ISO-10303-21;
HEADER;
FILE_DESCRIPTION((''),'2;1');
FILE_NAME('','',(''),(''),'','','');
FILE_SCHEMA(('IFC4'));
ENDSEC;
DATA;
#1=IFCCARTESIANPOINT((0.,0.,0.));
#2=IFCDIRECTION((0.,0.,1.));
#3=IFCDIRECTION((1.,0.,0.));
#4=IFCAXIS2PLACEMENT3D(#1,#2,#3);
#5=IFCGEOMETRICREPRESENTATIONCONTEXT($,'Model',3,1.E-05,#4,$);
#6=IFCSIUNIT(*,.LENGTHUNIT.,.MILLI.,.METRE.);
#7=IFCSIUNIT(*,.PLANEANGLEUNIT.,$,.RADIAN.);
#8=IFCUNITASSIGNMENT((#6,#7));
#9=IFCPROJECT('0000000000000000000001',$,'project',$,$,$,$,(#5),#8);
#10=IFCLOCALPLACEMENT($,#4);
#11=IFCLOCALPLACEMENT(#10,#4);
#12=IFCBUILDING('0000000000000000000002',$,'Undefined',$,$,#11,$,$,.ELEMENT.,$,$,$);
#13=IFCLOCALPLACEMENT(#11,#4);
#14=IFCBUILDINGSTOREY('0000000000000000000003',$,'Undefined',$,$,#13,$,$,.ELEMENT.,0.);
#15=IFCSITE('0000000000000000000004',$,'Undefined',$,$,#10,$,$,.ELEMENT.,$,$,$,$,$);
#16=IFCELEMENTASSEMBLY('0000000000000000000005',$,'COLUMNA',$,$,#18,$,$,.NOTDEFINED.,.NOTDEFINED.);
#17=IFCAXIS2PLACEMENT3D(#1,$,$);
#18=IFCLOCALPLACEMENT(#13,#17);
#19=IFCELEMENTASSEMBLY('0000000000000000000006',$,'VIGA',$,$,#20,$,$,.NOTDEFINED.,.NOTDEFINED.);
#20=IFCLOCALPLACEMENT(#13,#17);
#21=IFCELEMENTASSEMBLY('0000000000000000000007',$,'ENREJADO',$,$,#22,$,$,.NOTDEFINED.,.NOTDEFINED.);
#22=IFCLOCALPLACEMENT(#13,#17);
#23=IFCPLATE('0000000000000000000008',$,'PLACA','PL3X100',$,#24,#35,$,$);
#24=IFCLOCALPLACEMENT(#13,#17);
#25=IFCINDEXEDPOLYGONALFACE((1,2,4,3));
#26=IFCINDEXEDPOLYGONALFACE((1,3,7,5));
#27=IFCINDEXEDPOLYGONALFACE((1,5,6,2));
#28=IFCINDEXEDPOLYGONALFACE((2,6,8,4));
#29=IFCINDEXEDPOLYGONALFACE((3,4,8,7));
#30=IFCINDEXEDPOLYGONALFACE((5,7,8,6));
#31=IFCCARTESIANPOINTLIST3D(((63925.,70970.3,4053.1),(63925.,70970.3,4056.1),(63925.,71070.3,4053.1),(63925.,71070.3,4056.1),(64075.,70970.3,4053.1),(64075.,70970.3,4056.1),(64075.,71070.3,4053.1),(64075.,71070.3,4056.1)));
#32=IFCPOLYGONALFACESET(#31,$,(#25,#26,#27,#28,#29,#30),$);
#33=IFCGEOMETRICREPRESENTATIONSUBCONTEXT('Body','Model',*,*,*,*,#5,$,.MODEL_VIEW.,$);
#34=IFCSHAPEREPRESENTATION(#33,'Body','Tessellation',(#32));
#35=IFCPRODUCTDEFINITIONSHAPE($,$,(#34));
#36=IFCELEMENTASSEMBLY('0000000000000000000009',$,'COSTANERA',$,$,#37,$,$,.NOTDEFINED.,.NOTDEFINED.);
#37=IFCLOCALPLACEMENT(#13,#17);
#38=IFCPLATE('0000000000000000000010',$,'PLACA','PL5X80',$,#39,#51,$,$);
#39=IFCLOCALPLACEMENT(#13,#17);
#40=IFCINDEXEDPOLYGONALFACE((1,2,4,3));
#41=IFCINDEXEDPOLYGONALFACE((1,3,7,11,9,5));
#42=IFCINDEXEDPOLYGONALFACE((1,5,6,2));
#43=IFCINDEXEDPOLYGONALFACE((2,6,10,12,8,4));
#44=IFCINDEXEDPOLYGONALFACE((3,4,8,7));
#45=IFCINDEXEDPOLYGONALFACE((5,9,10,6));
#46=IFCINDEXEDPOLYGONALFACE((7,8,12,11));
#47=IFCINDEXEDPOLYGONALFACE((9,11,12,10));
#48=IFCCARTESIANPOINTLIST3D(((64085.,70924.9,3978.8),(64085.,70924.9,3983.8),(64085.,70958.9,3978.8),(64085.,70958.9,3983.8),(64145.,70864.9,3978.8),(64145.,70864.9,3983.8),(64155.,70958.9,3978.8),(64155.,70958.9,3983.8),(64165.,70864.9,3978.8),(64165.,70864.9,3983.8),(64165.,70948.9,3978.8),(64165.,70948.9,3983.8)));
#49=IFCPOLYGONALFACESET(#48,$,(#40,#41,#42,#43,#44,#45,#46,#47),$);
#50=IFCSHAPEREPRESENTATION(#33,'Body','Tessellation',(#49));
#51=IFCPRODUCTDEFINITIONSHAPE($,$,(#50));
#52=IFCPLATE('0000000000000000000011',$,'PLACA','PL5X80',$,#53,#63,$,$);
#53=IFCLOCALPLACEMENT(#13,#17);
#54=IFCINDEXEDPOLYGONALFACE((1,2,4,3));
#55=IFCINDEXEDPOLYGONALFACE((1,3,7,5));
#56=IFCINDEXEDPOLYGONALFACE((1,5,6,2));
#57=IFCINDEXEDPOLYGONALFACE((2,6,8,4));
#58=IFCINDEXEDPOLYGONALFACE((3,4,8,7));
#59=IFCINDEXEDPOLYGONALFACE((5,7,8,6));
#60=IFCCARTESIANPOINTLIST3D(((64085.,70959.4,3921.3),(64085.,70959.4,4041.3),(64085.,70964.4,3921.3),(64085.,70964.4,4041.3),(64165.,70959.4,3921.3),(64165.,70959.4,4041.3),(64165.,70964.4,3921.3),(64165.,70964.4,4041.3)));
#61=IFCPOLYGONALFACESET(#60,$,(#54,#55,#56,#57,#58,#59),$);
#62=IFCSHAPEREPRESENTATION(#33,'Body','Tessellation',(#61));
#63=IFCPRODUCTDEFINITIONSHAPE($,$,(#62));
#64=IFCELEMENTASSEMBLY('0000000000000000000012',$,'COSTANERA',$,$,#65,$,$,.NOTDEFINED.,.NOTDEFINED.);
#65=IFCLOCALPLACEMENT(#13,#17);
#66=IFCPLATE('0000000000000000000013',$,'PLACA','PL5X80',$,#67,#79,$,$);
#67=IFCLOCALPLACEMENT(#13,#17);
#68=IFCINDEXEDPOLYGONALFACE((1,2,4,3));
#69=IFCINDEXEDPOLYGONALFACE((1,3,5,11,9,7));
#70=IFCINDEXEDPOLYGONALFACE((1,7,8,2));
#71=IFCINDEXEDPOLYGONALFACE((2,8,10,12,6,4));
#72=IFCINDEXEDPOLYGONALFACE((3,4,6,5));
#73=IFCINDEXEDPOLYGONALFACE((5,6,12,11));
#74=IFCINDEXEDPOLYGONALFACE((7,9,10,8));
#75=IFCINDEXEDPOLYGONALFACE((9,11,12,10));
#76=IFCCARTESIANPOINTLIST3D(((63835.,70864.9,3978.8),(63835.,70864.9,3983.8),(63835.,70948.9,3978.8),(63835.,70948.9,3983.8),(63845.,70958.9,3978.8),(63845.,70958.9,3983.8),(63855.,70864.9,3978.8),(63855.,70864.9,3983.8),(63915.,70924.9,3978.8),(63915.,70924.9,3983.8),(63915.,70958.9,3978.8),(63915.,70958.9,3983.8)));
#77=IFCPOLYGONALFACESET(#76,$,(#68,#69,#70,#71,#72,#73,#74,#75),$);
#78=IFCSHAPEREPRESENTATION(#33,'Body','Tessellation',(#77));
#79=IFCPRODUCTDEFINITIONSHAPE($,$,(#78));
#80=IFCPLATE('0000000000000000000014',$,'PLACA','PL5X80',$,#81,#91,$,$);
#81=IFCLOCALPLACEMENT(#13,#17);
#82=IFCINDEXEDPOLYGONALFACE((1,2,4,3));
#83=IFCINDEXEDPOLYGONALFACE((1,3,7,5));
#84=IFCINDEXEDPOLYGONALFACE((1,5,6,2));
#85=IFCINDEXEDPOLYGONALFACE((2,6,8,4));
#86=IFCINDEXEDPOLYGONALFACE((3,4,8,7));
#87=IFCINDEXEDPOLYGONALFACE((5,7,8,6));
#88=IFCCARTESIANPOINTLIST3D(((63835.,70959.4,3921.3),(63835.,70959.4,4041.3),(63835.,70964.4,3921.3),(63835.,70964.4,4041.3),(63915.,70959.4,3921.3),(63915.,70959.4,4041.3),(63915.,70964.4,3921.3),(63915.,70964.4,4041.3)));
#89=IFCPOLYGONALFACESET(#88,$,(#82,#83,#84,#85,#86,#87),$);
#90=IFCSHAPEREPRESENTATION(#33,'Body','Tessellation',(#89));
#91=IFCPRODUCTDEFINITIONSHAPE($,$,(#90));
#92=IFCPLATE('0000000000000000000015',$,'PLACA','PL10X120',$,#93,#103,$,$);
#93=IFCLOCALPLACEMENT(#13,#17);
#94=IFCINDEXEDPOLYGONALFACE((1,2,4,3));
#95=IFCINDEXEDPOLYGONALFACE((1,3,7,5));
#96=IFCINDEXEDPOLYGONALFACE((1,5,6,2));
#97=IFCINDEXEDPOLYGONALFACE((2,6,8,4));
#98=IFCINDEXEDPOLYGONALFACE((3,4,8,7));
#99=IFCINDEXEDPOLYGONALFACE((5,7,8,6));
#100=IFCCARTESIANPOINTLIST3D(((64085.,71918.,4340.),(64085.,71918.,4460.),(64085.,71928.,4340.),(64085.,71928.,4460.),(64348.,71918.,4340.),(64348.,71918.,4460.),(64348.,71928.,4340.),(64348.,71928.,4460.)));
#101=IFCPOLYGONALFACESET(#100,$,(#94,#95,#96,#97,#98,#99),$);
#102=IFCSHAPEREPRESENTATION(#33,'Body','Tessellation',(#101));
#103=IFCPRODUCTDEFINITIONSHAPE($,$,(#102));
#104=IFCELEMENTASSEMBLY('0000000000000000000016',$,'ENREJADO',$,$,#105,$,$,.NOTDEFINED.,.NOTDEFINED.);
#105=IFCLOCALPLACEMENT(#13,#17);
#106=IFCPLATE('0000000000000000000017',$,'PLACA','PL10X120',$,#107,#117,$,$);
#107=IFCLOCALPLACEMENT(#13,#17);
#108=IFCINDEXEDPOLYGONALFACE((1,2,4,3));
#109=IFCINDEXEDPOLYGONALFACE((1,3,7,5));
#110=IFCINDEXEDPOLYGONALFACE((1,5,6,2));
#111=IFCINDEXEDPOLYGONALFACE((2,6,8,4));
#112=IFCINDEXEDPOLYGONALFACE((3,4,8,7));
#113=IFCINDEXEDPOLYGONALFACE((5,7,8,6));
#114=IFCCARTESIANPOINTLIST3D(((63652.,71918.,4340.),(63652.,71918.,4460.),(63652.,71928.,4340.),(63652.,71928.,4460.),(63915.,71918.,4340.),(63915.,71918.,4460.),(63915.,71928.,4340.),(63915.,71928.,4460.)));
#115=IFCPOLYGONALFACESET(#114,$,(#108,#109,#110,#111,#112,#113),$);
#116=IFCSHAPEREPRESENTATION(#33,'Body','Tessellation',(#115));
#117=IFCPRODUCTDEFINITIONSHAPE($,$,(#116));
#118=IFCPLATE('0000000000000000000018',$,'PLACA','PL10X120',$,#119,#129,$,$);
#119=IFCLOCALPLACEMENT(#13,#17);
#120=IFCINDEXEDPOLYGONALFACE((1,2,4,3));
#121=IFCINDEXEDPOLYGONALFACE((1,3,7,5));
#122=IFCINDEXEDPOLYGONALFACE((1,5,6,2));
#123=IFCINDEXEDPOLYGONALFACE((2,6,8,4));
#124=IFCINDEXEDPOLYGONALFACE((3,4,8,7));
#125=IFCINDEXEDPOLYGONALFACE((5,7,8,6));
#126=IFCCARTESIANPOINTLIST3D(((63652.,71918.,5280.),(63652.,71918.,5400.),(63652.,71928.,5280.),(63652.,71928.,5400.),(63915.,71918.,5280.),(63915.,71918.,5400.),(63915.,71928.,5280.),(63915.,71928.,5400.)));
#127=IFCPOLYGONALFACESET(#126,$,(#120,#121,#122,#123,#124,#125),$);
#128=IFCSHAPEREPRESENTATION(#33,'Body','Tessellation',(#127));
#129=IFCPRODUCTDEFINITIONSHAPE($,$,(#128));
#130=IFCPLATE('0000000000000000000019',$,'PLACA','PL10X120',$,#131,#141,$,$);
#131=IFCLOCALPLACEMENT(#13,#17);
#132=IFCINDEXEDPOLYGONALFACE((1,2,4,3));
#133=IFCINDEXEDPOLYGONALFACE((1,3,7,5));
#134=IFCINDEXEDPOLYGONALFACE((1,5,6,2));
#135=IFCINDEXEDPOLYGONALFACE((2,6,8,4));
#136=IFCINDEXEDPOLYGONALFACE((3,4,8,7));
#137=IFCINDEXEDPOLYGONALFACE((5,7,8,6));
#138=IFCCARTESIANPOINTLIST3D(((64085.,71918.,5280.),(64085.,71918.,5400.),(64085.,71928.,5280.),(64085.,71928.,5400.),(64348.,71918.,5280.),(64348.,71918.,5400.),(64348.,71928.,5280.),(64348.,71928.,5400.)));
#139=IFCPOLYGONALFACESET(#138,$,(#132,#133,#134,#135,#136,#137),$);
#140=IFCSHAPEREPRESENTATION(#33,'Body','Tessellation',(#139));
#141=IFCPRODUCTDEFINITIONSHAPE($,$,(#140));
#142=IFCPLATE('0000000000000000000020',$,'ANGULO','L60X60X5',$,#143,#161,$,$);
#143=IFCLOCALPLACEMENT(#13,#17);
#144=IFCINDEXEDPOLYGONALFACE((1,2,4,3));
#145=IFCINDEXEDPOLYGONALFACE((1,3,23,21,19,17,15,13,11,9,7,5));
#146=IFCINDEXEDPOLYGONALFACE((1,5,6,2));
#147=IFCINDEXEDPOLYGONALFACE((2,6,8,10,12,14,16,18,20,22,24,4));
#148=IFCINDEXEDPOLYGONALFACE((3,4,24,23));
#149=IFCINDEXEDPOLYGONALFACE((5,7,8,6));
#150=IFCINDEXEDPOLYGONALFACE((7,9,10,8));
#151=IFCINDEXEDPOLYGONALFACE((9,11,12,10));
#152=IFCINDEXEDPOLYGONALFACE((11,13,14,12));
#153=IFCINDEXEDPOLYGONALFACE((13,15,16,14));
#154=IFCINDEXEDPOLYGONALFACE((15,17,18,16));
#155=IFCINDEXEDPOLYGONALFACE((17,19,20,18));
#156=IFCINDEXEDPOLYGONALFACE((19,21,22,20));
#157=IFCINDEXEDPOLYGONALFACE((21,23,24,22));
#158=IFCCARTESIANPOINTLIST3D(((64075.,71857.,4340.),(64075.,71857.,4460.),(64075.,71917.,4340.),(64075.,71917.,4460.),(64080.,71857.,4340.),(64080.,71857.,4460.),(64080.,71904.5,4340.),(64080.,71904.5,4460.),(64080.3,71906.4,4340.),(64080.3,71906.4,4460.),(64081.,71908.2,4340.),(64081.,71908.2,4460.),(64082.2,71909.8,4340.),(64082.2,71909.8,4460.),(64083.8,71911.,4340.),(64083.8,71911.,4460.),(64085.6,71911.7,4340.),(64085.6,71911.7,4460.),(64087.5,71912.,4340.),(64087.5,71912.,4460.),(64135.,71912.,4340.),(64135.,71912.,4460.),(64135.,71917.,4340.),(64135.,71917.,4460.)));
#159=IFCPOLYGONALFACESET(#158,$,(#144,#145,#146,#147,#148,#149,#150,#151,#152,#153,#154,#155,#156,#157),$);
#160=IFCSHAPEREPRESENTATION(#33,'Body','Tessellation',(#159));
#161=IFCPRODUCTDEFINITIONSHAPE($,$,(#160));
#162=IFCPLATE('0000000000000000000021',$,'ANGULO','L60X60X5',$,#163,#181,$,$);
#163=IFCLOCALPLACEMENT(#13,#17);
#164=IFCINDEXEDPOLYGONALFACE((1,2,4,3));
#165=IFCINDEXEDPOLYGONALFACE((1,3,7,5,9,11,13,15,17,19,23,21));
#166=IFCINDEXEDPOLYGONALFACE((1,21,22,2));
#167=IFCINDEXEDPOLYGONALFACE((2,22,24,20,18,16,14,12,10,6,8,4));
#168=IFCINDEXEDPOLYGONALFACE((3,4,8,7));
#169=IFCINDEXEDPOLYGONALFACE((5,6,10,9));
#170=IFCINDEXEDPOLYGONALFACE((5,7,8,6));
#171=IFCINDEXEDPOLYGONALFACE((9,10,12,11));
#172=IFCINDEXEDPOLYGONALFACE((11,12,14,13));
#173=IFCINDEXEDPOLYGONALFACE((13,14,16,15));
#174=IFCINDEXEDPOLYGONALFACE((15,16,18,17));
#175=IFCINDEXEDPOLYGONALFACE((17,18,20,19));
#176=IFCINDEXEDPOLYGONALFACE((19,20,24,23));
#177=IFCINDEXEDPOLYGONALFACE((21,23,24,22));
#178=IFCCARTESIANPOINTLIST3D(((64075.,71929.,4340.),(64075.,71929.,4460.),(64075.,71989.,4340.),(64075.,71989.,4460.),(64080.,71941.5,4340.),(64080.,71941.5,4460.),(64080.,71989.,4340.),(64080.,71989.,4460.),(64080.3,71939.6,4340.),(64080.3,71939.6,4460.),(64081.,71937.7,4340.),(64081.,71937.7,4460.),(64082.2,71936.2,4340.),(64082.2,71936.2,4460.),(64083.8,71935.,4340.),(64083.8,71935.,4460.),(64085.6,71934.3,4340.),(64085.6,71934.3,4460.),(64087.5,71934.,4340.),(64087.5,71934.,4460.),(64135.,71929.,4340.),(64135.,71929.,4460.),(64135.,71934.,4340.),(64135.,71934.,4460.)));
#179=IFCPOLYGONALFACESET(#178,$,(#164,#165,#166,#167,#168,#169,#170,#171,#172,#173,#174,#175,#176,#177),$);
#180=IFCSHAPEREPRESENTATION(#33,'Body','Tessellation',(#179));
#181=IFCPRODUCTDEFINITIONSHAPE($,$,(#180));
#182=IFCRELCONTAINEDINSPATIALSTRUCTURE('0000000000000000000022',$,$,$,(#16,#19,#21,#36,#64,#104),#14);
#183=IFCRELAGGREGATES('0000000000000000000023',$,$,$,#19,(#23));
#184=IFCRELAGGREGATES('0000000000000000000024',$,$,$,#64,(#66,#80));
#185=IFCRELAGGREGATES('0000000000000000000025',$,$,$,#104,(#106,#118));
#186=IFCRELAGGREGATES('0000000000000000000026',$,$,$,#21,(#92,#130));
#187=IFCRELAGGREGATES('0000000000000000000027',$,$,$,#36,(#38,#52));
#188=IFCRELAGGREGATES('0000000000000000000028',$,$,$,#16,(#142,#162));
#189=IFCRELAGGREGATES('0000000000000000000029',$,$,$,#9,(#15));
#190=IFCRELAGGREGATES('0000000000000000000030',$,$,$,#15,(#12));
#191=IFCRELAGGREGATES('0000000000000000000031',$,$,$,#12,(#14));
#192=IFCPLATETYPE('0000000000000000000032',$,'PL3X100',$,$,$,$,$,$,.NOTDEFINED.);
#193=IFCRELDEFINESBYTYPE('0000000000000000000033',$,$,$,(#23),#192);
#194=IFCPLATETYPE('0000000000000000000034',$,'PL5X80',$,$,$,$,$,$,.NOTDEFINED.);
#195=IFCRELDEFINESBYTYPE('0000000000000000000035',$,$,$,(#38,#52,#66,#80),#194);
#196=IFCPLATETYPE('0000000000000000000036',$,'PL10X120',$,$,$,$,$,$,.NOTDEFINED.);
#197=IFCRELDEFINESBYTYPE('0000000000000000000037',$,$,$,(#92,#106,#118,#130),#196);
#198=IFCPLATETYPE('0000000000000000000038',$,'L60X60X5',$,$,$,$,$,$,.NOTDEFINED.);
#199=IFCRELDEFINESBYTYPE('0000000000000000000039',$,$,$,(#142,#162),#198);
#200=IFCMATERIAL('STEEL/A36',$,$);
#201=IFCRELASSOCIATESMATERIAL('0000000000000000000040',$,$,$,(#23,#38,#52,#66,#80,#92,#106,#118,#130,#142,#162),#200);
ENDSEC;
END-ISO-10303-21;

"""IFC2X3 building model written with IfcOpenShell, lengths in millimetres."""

from ifc_helpers import new_model, si_unit, frame, origin_with_axes, origin_2d_with_axis, place, context, subcontext, project, spatial, polyline, l_section, outline, extrude, material, type_object, element, aggregate, save


model = new_model("IFC2X3")

# Units and contexts
model_context = context("Model", 3, precision=1e-05, world=origin_with_axes())
body_context = subcontext(model_context, "Body", "Model", "MODEL_VIEW")
ifc_project = project(units=[si_unit("LENGTHUNIT", "METRE", prefix="MILLI"), si_unit("PLANEANGLEUNIT", "RADIAN")], contexts=[model_context])

# Site, building, storey
site_placement = place(None, origin_with_axes())
site = spatial("IfcSite", under=ifc_project, at=site_placement, Name="Undefined", CompositionType="ELEMENT")
building_placement = place(site_placement, origin_with_axes())
building = spatial("IfcBuilding", under=site, at=building_placement, Name="Undefined", CompositionType="ELEMENT")
storey_placement = place(building_placement, origin_with_axes())
storey = spatial("IfcBuildingStorey", under=building, at=storey_placement, Name="Undefined", CompositionType="ELEMENT", Elevation=0.0)

# Element assembly
assembly_1_placement = place(storey_placement, origin_with_axes())
assembly_1 = element("IfcElementAssembly", 1, at=assembly_1_placement, inside=storey, Name="COLUMNA", AssemblyPlace="NOTDEFINED", PredefinedType="NOTDEFINED")
ifc_material_1 = material(Name="STEEL/A36")

# Element assemblies
assembly_2_placement = place(storey_placement, origin_with_axes())
assembly_2 = element("IfcElementAssembly", 2, at=assembly_2_placement, inside=storey, Name="VIGA", AssemblyPlace="NOTDEFINED", PredefinedType="NOTDEFINED")
assembly_3_placement = place(storey_placement, origin_with_axes())
assembly_3 = element("IfcElementAssembly", 3, at=assembly_3_placement, inside=storey, Name="ENREJADO", AssemblyPlace="NOTDEFINED", PredefinedType="NOTDEFINED")

# Plate
plate_type_1 = type_object("IfcPlateType", Name="PL3X100", PredefinedType="NOTDEFINED")
plate_1_placement = place(assembly_2_placement, frame((64075.0, 71070.3, 4054.6), z_axis=(0.0, 0.0, -1.0), x_axis=(0.0, -1.0, 0.0)))
plate_1 = element("IfcPlate", 4, at=plate_1_placement, type_object=plate_type_1, material=ifc_material_1, Name="PLACA", Description="PL3X100", context=body_context, shape_type="SweptSolid", body=[
    extrude(outline(polyline([(0.0, 0.0), (100.0, 0.0), (100.0, 150.0), (0.0, 150.0), (0.0, 0.0)])), frame((0.0, 0.0, -1.5), z_axis=(0.0, 0.0, 1.0), x_axis=(1.0, 0.0, 0.0)), (0.0, 0.0, 1.0), 3.0),
])
aggregate(assembly_2, [plate_1])

# Element assemblies, plates
assembly_4_placement = place(storey_placement, origin_with_axes())
assembly_4 = element("IfcElementAssembly", 5, at=assembly_4_placement, inside=storey, Name="COSTANERA", AssemblyPlace="NOTDEFINED", PredefinedType="NOTDEFINED")
plate_type_2 = type_object("IfcPlateType", Name="PL5X80", PredefinedType="NOTDEFINED")
plate_2_placement = place(assembly_4_placement, frame((64085.0, 70958.9, 3981.3), z_axis=(0.0, 0.0, -1.0), x_axis=(1.0, 0.0, 0.0)))
plate_2 = element("IfcPlate", 6, at=plate_2_placement, type_object=plate_type_2, material=ifc_material_1, Name="PLACA", Description="PL5X80", context=body_context, shape_type="SweptSolid", body=[
    extrude(outline(polyline([(0.0, 0.0), (70.0, 0.0), (80.0, 10.0), (80.0, 94.0), (60.0, 94.0), (0.0, 34.0), (0.0, 0.0)])), frame((0.0, 0.0, -2.5), z_axis=(0.0, 0.0, 1.0), x_axis=(1.0, 0.0, 0.0)), (0.0, 0.0, 1.0), 5.0),
])
plate_3_placement = place(assembly_4_placement, frame((64085.0, 70961.9, 4041.3), z_axis=(0.0, 1.0, 0.0), x_axis=(1.0, 0.0, 0.0)))
plate_3 = element("IfcPlate", 7, at=plate_3_placement, type_object=plate_type_2, material=ifc_material_1, Name="PLACA", Description="PL5X80", context=body_context, shape_type="SweptSolid", body=[
    extrude(outline(polyline([(0.0, 0.0), (80.0, 0.0), (80.0, 120.0), (0.0, 120.0), (0.0, 0.0)])), frame((0.0, 0.0, -2.5), z_axis=(0.0, 0.0, 1.0), x_axis=(1.0, 0.0, 0.0)), (0.0, 0.0, 1.0), 5.0),
])
assembly_5_placement = place(storey_placement, origin_with_axes())
assembly_5 = element("IfcElementAssembly", 8, at=assembly_5_placement, inside=storey, Name="COSTANERA", AssemblyPlace="NOTDEFINED", PredefinedType="NOTDEFINED")
plate_4_placement = place(assembly_5_placement, frame((63915.0, 70958.9, 3981.3), z_axis=(0.0, 0.0, 1.0), x_axis=(-1.0, 0.0, 0.0)))
plate_4 = element("IfcPlate", 9, at=plate_4_placement, type_object=plate_type_2, material=ifc_material_1, Name="PLACA", Description="PL5X80", context=body_context, shape_type="SweptSolid", body=[
    extrude(outline(polyline([(0.0, 0.0), (70.0, 0.0), (80.0, 10.0), (80.0, 94.0), (60.0, 94.0), (0.0, 34.0), (0.0, 0.0)])), frame((0.0, 0.0, -2.5), z_axis=(0.0, 0.0, 1.0), x_axis=(1.0, 0.0, 0.0)), (0.0, 0.0, 1.0), 5.0),
])
plate_5_placement = place(assembly_5_placement, frame((63915.0, 70961.9, 4041.3), z_axis=(0.0, -1.0, 0.0), x_axis=(-1.0, 0.0, 0.0)))
plate_5 = element("IfcPlate", 10, at=plate_5_placement, type_object=plate_type_2, material=ifc_material_1, Name="PLACA", Description="PL5X80", context=body_context, shape_type="SweptSolid", body=[
    extrude(outline(polyline([(0.0, 0.0), (80.0, 0.0), (80.0, 120.0), (0.0, 120.0), (0.0, 0.0)])), frame((0.0, 0.0, -2.5), z_axis=(0.0, 0.0, 1.0), x_axis=(1.0, 0.0, 0.0)), (0.0, 0.0, 1.0), 5.0),
])
aggregate(assembly_5, [plate_4, plate_5])

# Plate
plate_type_3 = type_object("IfcPlateType", Name="PL10X120", PredefinedType="NOTDEFINED")
plate_6_placement = place(assembly_3_placement, frame((64085.0, 71923.0, 4400.0), z_axis=(0.0, 1.0, 0.0), x_axis=(1.0, 0.0, 0.0)))
plate_6 = element("IfcPlate", 11, at=plate_6_placement, type_object=plate_type_3, material=ifc_material_1, Name="PLACA", Description="PL10X120", context=body_context, shape_type="SweptSolid", body=[
    extrude(outline(polyline([(0.0, -60.0), (0.0, 60.0), (263.0, 60.0), (263.0, -60.0), (0.0, -60.0)])), frame((0.0, 0.0, -5.0), z_axis=(0.0, 0.0, 1.0), x_axis=(1.0, 0.0, 0.0)), (0.0, 0.0, 1.0), 10.0),
])

# Element assembly, plates
assembly_6_placement = place(storey_placement, origin_with_axes())
assembly_6 = element("IfcElementAssembly", 12, at=assembly_6_placement, inside=storey, Name="ENREJADO", AssemblyPlace="NOTDEFINED", PredefinedType="NOTDEFINED")
plate_7_placement = place(assembly_6_placement, frame((63915.0, 71923.0, 4400.0), z_axis=(0.0, 1.0, 0.0), x_axis=(-1.0, 0.0, 0.0)))
plate_7 = element("IfcPlate", 13, at=plate_7_placement, type_object=plate_type_3, material=ifc_material_1, Name="PLACA", Description="PL10X120", context=body_context, shape_type="SweptSolid", body=[
    extrude(outline(polyline([(0.0, -60.0), (0.0, 60.0), (263.0, 60.0), (263.0, -60.0), (0.0, -60.0)])), frame((0.0, 0.0, -5.0), z_axis=(0.0, 0.0, 1.0), x_axis=(1.0, 0.0, 0.0)), (0.0, 0.0, 1.0), 10.0),
])
plate_8_placement = place(assembly_6_placement, frame((63915.0, 71923.0, 5340.0), z_axis=(0.0, -1.0, 0.0), x_axis=(-1.0, 0.0, 0.0)))
plate_8 = element("IfcPlate", 14, at=plate_8_placement, type_object=plate_type_3, material=ifc_material_1, Name="PLACA", Description="PL10X120", context=body_context, shape_type="SweptSolid", body=[
    extrude(outline(polyline([(0.0, -60.0), (0.0, 60.0), (263.0, 60.0), (263.0, -60.0), (0.0, -60.0)])), frame((0.0, 0.0, -5.0), z_axis=(0.0, 0.0, 1.0), x_axis=(1.0, 0.0, 0.0)), (0.0, 0.0, 1.0), 10.0),
])
aggregate(assembly_6, [plate_7, plate_8])

# Plates
plate_9_placement = place(assembly_3_placement, frame((64085.0, 71923.0, 5340.0), z_axis=(0.0, 1.0, 0.0), x_axis=(1.0, 0.0, 0.0)))
plate_9 = element("IfcPlate", 15, at=plate_9_placement, type_object=plate_type_3, material=ifc_material_1, Name="PLACA", Description="PL10X120", context=body_context, shape_type="SweptSolid", body=[
    extrude(outline(polyline([(0.0, -60.0), (0.0, 60.0), (263.0, 60.0), (263.0, -60.0), (0.0, -60.0)])), frame((0.0, 0.0, -5.0), z_axis=(0.0, 0.0, 1.0), x_axis=(1.0, 0.0, 0.0)), (0.0, 0.0, 1.0), 10.0),
])
aggregate(assembly_3, [plate_6, plate_9])
plate_type_4 = type_object("IfcPlateType", Name="L60X60X5", PredefinedType="NOTDEFINED")
plate_10_placement = place(assembly_1_placement, frame((64105.0, 71887.0, 4340.0), z_axis=(0.0, -1.0, 0.0), x_axis=(0.0, 0.0, 1.0)))
plate_10 = element("IfcPlate", 16, at=plate_10_placement, type_object=plate_type_4, material=ifc_material_1, Name="ANGULO", Description="L60X60X5", context=body_context, shape_type="SweptSolid", body=[
    extrude(l_section(Depth=60.0, Width=60.0, Thickness=5.0, FilletRadius=7.5, at=origin_2d_with_axis()), frame((120.0, 0.0, 0.0), z_axis=(-1.0, 0.0, 0.0), x_axis=(0.0, -1.0, 0.0)), (0.0, 0.0, 1.0), 120.0),
])
plate_11_placement = place(assembly_1_placement, frame((64105.0, 71959.0, 4460.0), z_axis=(0.0, 1.0, 0.0), x_axis=(0.0, 0.0, -1.0)))
plate_11 = element("IfcPlate", 17, at=plate_11_placement, type_object=plate_type_4, material=ifc_material_1, Name="ANGULO", Description="L60X60X5", context=body_context, shape_type="SweptSolid", body=[
    extrude(l_section(Depth=60.0, Width=60.0, Thickness=5.0, FilletRadius=7.5, at=origin_2d_with_axis()), frame((120.0, 0.0, 0.0), z_axis=(-1.0, 0.0, 0.0), x_axis=(0.0, -1.0, 0.0)), (0.0, 0.0, 1.0), 120.0),
])

aggregate(assembly_4, [plate_2, plate_3])
aggregate(assembly_1, [plate_10, plate_11])

save(model, "model.ifc")
